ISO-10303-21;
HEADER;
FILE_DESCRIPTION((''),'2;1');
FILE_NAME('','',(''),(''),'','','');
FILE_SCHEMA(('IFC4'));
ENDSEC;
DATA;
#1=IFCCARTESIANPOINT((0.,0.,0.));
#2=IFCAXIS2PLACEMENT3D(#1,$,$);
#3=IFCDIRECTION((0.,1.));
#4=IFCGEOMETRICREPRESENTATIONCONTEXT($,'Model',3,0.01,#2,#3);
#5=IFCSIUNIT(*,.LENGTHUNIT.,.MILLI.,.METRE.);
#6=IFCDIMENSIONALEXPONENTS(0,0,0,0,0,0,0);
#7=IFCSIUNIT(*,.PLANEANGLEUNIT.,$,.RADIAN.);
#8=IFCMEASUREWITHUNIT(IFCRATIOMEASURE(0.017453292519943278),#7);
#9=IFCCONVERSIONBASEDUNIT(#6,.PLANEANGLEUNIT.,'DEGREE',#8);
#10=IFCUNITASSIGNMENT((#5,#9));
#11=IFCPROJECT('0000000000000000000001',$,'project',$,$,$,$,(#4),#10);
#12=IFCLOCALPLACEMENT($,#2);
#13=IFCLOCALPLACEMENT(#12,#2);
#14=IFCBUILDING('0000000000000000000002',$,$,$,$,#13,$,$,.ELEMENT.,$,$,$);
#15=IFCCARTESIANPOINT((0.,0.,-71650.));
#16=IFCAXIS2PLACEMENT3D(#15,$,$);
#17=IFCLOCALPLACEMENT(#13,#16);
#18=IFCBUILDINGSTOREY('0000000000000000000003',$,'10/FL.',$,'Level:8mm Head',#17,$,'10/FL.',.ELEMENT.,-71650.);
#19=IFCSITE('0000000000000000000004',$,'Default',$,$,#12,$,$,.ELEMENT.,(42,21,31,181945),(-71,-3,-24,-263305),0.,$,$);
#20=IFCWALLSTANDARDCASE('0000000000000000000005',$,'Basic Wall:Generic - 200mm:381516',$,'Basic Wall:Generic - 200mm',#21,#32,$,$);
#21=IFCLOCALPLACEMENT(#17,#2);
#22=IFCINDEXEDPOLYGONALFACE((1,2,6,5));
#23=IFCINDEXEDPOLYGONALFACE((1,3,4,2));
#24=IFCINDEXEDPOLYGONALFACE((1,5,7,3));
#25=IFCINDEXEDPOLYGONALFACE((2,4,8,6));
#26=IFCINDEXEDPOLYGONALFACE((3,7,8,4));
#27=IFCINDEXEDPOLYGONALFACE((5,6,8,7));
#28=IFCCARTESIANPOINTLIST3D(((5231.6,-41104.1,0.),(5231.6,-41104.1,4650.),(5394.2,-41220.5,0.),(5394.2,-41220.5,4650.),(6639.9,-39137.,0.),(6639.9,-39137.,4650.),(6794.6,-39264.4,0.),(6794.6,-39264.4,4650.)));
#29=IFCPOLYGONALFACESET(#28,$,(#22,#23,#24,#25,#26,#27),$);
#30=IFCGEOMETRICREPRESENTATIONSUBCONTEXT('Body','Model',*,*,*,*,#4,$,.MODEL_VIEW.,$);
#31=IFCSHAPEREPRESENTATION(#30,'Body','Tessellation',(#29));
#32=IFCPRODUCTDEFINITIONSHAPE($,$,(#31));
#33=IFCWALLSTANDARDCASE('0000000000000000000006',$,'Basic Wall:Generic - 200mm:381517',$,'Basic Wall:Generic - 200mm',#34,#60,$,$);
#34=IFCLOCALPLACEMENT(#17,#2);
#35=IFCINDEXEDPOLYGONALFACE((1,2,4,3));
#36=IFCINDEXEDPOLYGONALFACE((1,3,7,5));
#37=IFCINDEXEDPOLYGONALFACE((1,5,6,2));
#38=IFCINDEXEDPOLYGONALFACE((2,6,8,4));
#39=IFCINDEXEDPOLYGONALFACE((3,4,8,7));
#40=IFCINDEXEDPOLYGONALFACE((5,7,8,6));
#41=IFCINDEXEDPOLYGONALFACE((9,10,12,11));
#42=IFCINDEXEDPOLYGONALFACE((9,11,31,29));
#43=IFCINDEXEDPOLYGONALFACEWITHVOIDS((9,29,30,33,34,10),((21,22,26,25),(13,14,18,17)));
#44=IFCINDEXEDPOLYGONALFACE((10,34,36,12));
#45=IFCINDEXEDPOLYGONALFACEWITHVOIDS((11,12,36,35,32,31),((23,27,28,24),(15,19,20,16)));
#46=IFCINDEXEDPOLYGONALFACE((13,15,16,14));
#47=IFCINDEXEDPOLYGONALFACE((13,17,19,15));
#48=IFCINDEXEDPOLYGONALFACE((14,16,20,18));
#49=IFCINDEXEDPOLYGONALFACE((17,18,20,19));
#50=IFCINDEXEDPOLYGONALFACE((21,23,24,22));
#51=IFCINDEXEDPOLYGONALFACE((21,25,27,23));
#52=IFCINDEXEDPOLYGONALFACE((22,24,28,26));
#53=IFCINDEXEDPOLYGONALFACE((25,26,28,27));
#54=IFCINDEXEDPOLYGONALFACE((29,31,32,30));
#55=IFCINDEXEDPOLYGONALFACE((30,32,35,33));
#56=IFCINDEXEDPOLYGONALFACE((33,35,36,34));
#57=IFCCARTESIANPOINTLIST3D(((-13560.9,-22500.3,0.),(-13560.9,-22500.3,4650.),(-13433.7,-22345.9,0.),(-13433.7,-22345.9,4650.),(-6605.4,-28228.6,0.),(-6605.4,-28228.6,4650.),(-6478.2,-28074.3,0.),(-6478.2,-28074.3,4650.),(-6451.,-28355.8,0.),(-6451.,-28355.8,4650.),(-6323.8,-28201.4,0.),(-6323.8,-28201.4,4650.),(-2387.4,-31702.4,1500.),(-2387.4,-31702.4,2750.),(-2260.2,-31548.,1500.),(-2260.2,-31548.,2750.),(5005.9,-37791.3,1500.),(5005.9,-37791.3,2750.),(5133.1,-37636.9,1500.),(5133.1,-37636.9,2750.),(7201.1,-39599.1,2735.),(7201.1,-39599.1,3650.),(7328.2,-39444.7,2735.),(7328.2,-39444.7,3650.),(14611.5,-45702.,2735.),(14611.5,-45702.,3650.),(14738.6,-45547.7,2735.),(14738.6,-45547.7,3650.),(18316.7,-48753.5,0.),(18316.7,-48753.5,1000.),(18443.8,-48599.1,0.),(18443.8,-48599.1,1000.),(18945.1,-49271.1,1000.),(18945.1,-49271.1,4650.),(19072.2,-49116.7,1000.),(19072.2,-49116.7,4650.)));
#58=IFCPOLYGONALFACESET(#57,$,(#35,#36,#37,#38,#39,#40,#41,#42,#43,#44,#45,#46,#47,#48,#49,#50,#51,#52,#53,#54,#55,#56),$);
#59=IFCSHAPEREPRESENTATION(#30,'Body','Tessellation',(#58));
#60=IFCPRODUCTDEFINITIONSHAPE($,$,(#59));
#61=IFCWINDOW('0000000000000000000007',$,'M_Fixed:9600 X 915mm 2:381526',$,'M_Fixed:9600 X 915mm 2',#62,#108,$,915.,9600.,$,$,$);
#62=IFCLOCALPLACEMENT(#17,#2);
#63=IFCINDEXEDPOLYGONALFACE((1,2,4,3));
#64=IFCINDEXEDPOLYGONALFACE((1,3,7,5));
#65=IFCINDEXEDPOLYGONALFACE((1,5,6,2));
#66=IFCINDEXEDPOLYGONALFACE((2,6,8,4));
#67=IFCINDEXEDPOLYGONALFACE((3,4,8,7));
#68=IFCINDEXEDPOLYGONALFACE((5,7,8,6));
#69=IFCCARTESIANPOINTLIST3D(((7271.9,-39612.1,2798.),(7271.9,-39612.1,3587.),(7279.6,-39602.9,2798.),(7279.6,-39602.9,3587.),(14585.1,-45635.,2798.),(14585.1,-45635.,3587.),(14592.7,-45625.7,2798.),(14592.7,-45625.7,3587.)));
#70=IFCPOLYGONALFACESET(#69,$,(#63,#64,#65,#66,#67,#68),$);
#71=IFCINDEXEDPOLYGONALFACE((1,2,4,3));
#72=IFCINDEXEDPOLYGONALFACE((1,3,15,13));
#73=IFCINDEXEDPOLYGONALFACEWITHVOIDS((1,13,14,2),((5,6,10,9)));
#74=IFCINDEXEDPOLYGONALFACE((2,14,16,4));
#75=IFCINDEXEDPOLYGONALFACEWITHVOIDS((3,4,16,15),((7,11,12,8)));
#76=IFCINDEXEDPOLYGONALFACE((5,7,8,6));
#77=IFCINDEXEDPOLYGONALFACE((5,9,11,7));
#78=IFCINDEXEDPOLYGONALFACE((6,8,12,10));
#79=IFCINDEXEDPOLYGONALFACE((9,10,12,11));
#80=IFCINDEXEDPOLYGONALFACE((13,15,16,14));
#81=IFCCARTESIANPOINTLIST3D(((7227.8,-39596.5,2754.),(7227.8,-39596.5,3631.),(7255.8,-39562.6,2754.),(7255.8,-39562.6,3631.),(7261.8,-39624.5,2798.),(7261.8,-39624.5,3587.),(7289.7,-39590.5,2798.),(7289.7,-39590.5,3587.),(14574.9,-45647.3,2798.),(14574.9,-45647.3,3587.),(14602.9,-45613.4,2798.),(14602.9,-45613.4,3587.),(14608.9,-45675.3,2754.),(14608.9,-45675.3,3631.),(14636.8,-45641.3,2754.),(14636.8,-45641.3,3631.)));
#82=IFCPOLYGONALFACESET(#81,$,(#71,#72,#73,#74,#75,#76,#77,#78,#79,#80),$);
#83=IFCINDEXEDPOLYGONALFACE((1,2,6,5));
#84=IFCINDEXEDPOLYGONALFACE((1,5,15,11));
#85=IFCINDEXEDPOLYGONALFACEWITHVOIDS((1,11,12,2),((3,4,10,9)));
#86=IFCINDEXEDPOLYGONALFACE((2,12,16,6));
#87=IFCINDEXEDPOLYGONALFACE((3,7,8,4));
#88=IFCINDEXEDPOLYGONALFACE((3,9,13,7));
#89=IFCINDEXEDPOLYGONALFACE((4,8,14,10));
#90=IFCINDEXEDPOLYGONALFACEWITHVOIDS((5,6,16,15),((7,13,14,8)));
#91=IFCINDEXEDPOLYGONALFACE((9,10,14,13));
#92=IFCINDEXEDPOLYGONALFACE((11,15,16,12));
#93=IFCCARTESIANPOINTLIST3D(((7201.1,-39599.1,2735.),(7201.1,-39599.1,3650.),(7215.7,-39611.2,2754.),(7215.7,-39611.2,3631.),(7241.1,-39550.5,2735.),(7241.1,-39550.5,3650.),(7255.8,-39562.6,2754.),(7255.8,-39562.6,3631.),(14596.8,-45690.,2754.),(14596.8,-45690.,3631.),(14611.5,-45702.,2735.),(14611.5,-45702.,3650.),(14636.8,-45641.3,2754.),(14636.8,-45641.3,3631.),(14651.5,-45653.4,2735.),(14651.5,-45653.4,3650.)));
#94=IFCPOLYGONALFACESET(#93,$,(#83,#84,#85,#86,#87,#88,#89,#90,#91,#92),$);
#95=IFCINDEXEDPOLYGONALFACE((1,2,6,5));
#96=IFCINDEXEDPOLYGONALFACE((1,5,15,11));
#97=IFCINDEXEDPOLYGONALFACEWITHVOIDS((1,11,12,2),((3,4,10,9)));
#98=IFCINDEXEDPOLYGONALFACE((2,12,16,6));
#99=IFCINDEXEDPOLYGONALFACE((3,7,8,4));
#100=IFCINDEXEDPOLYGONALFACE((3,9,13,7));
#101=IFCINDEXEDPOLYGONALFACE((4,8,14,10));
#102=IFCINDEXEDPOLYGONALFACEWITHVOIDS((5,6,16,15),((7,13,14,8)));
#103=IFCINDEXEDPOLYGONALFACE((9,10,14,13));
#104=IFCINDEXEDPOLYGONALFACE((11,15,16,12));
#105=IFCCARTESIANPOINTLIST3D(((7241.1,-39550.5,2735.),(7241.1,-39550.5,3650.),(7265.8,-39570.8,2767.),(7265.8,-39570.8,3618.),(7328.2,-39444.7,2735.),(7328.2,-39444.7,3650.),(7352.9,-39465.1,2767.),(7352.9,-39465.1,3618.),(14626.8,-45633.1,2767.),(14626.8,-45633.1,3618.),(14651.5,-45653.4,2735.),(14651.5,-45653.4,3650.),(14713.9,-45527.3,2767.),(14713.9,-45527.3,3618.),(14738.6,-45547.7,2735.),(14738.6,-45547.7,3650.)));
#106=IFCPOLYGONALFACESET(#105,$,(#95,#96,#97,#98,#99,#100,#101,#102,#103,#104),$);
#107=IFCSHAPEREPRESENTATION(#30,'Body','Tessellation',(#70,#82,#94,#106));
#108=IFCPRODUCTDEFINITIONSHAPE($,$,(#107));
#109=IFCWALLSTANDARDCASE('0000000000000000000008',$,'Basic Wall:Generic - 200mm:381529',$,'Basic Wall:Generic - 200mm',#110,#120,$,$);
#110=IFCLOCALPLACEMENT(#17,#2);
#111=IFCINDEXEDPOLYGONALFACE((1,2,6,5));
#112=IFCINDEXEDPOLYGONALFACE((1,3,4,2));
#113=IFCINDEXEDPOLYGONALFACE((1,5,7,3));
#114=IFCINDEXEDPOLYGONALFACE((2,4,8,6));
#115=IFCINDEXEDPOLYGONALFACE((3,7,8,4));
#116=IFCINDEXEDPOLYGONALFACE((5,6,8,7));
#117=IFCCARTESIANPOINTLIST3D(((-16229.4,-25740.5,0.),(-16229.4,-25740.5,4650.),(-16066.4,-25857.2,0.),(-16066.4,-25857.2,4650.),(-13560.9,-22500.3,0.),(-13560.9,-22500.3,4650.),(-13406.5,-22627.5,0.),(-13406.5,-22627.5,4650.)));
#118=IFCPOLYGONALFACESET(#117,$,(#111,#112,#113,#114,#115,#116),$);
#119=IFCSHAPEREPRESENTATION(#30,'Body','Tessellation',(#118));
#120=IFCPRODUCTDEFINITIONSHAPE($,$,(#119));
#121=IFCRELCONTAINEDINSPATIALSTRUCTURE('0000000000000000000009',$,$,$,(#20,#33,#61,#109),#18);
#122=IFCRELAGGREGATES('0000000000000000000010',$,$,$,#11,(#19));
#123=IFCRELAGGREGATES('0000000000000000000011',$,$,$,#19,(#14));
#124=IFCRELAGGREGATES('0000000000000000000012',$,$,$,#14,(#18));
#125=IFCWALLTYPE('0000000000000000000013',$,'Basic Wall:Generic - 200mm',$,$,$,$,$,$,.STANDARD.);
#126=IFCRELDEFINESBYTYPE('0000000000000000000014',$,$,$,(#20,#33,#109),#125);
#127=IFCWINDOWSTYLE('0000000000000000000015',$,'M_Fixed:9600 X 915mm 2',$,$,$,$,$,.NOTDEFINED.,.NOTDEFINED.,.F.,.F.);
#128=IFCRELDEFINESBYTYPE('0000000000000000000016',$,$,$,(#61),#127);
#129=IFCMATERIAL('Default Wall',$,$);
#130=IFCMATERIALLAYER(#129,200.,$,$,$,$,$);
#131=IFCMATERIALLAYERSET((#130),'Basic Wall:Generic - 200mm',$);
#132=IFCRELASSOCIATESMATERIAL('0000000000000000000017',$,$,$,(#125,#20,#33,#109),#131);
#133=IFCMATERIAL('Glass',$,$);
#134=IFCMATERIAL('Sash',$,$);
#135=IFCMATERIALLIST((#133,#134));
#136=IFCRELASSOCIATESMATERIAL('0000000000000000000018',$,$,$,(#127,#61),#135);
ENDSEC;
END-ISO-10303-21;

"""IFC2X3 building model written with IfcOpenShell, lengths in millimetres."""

from ifc_helpers import new_model, entity, si_unit, converted_unit, direction, frame, frame_2d, origin, place, context, subcontext, project, spatial, polyline, rectangle, outline, extrude, source, transform, mapped, material, material_list, layer, layer_set, layer_usage, type_object, type_shapes, element, fill, save


model = new_model("IFC2X3")

# Units and contexts
model_context = context("Model", 3, precision=0.01, world=origin(), true_north=direction((0.0, 1.0)))
body_context = subcontext(model_context, "Body", "Model", "MODEL_VIEW")
ifc_project = project(units=[si_unit("LENGTHUNIT", "METRE", prefix="MILLI"), converted_unit("PLANEANGLEUNIT", "DEGREE", entity("IfcRatioMeasure", 0.017453292519943278), si_unit("PLANEANGLEUNIT", "RADIAN"), dimensions=[0, 0, 0, 0, 0, 0, 0])], contexts=[model_context])

# Site, building, storey
site_placement = place(None, origin())
site = spatial("IfcSite", under=ifc_project, at=site_placement, Name="Default", CompositionType="ELEMENT", RefLatitude=(42, 21, 31, 181945), RefLongitude=(-71, -3, -24, -263305), RefElevation=0.0)
building_placement = place(site_placement, origin())
building = spatial("IfcBuilding", under=site, at=building_placement, CompositionType="ELEMENT")
storey_placement = place(building_placement, frame((0.0, 0.0, -71650.0)))
storey = spatial("IfcBuildingStorey", under=building, at=storey_placement, Name="10/FL.", ObjectType="Level:8mm Head", LongName="10/FL.", CompositionType="ELEMENT", Elevation=-71650.0)

# Shared definitions
ifc_material_1 = material(Name="Default Wall")
ifc_layer = layer(ifc_material_1, 200.0)
ifc_layer_set = layer_set([ifc_layer], Name="Basic Wall:Generic - 200mm")
ifc_layer_usage = layer_usage(ifc_layer_set, "AXIS2", "NEGATIVE", 100.0)
wall_type = type_object("IfcWallType", Name="Basic Wall:Generic - 200mm", PredefinedType="STANDARD", material=ifc_layer_set)

# Shared definitions
ifc_material_2 = material(Name="Glass")
ifc_material_3 = material(Name="Sash")
ifc_material_list = material_list([ifc_material_2, ifc_material_3])

# Wall
wall_1_placement = place(storey_placement, frame((5312.9, -41162.3, 0.0), z_axis=(0.0, 0.0, 1.0), x_axis=(0.582098, 0.813119, 0.0)))
element("IfcWallStandardCase", 1, at=wall_1_placement, inside=storey, type_object=wall_type, material=ifc_layer_usage, Name="Basic Wall:Generic - 200mm:381516", ObjectType="Basic Wall:Generic - 200mm", context=body_context, shape_type="SweptSolid", body=[
    extrude(outline(polyline([(2405.7, -100.0), (2419.3, 100.0), (0.0, 100.0), (0.0, -100.0), (2405.7, -100.0)])), origin(), (0.0, 0.0, 1.0), 4650.0),
])

# Wall, openings, window
wall_2_placement = place(storey_placement, frame((-13497.3, -22423.1, 0.0), z_axis=(0.0, 0.0, 1.0), x_axis=(0.771917, -0.635723, 0.0)))
wall_2 = element("IfcWallStandardCase", 2, at=wall_2_placement, inside=storey, type_object=wall_type, material=ifc_layer_usage, Name="Basic Wall:Generic - 200mm:381517", ObjectType="Basic Wall:Generic - 200mm", context=body_context, shape_type="SweptSolid", body=[
    extrude(rectangle(XDim=42110.7, YDim=200.0, at=frame_2d((21055.3, 0.0), x_axis=(-1.0, 0.0))), origin(), (0.0, 0.0, 1.0), 4650.0),
])
opening_1_placement = place(storey_placement, frame((-13497.3, -22423.1, 0.0), z_axis=(0.0, 0.0, 1.0), x_axis=(0.771917, -0.635723, 0.0)))
element("IfcOpeningElement", 3, at=opening_1_placement, cuts=wall_2, ObjectType="Opening", context=body_context, shape_type="SweptSolid", body=[
    extrude(rectangle(XDim=4650.0, YDim=200.0, at=frame_2d((0.0, 0.0), x_axis=(1.0, 0.0))), frame((9010.7, 0.0, 2325.0), z_axis=(1.0, 0.0, 0.0), x_axis=(0.0, 0.0, -1.0)), (0.0, 0.0, 1.0), 200.0),
])
opening_2_placement = place(wall_2_placement, origin())
element("IfcOpeningElement", 4, at=opening_2_placement, cuts=wall_2, ObjectType="Opening", context=body_context, shape_type="SweptSolid", body=[
    extrude(rectangle(XDim=1250.0, YDim=9577.8, at=frame_2d((0.0, 0.0), x_axis=(1.0, 0.0))), frame((19263.9, -100.0, 2125.0), z_axis=(0.0, 1.0, 0.0), x_axis=(0.0, 0.0, -1.0)), (0.0, 0.0, 1.0), 200.0),
])
opening_3_placement = place(wall_2_placement, frame((-3836.1, 25889.3, 0.0), z_axis=(0.0, 0.0, 1.0), x_axis=(0.771917, 0.635723, 0.0)))
element("IfcOpeningElement", 5, at=opening_3_placement, cuts=wall_2, ObjectType="Opening", context=body_context, shape_type="SweptSolid", body=[
    extrude(rectangle(XDim=1000.0, YDim=1010.1, at=frame_2d((0.0, 0.0), x_axis=(1.0, 0.0))), frame((18698.4, -49084.4, 500.0), z_axis=(0.635723, 0.771917, 0.0), x_axis=(0.0, 0.0, -1.0)), (0.0, 0.0, 1.0), 1012.7),
])
opening_4_placement = place(wall_2_placement, frame((36496.6, 100.0, 2735.0)))
opening_4 = element("IfcOpeningElement", 6, at=opening_4_placement, cuts=wall_2, ObjectType="Opening", context=body_context, shape_type="SweptSolid", body=[
    extrude(rectangle(XDim=915.0, YDim=9600.0, at=frame_2d((457.5, 4800.0), x_axis=(1.0, 0.0))), frame((0.0, 0.0, 0.0), z_axis=(0.0, -1.0, 0.0), x_axis=(0.0, 0.0, 1.0)), (0.0, 0.0, 1.0), 200.0),
])
window_style_1 = type_object("IfcWindowStyle", Name="M_Fixed:9600 X 915mm 2", ConstructionType="NOTDEFINED", OperationType="NOTDEFINED", ParameterTakesPrecedence=False, Sizeable=False, material=ifc_material_list)
shared_shape_1 = source(origin(), body_context, "Body", "SweptSolid", [
    extrude(rectangle(XDim=12.0, YDim=9474.0, at=frame_2d((0.0, 0.0), x_axis=(1.0, 0.0))), frame((4800.0, 159.0, 63.0), z_axis=(0.0, 0.0, 1.0), x_axis=(0.0, -1.0, 0.0)), (0.0, 0.0, 1.0), 789.0),
    extrude(outline(polyline([(-4781.0, -438.5), (4781.0, -438.5), (4781.0, 438.5), (-4781.0, 438.5), (-4781.0, -438.5)]), holes=[polyline([(-4737.0, -394.5), (-4737.0, 394.5), (4737.0, 394.5), (4737.0, -394.5), (-4737.0, -394.5)])]), frame((4800.0, 137.0, 457.5), z_axis=(0.0, 1.0, 0.0), x_axis=(1.0, 0.0, 0.0)), (0.0, 0.0, 1.0), 44.0),
    extrude(outline(polyline([(-4800.0, -457.5), (4800.0, -457.5), (4800.0, 457.5), (-4800.0, 457.5), (-4800.0, -457.5)]), holes=[polyline([(-4781.0, -438.5), (-4781.0, 438.5), (4781.0, 438.5), (4781.0, -438.5), (-4781.0, -438.5)])]), frame((4800.0, 137.0, 457.5), z_axis=(0.0, 1.0, 0.0), x_axis=(1.0, 0.0, 0.0)), (0.0, 0.0, 1.0), 63.0),
    extrude(outline(polyline([(-4800.0, -457.5), (4800.0, -457.5), (4800.0, 457.5), (-4800.0, 457.5), (-4800.0, -457.5)]), holes=[polyline([(-4768.0, -425.5), (-4768.0, 425.5), (4768.0, 425.5), (4768.0, -425.5), (-4768.0, -425.5)])]), frame((4800.0, 0.0, 457.5), z_axis=(0.0, 1.0, 0.0), x_axis=(1.0, 0.0, 0.0)), (0.0, 0.0, 1.0), 137.0),
])
type_shapes(window_style_1, [shared_shape_1])
window_1_placement = place(opening_4_placement, frame((0.0, 0.0, 0.0), z_axis=(0.0, 0.0, 1.0), x_axis=(-1.0, 0.0, 0.0)))
window_1 = element("IfcWindow", 7, at=window_1_placement, inside=storey, type_object=window_style_1, material=ifc_material_list, Name="M_Fixed:9600 X 915mm 2:381526", ObjectType="M_Fixed:9600 X 915mm 2", OverallHeight=915.0, OverallWidth=9600.0, context=body_context, shape_type="MappedRepresentation", body=[
    mapped(shared_shape_1, transform((0.0, 0.0, 0.0), scale=1.0)),
])
fill(opening_4, window_1)

# Wall
wall_3_placement = place(storey_placement, frame((-16152.2, -25804.1, 0.0), z_axis=(0.0, 0.0, 1.0), x_axis=(0.635723, 0.771917, 0.0)))
element("IfcWallStandardCase", 8, at=wall_3_placement, inside=storey, type_object=wall_type, material=ifc_layer_usage, Name="Basic Wall:Generic - 200mm:381529", ObjectType="Basic Wall:Generic - 200mm", context=body_context, shape_type="SweptSolid", body=[
    extrude(outline(polyline([(4197.6, -100.0), (4197.6, 100.0), (0.0, 100.0), (13.5, -100.0), (4197.6, -100.0)])), origin(), (0.0, 0.0, 1.0), 4650.0),
])

save(model, "model.ifc")
